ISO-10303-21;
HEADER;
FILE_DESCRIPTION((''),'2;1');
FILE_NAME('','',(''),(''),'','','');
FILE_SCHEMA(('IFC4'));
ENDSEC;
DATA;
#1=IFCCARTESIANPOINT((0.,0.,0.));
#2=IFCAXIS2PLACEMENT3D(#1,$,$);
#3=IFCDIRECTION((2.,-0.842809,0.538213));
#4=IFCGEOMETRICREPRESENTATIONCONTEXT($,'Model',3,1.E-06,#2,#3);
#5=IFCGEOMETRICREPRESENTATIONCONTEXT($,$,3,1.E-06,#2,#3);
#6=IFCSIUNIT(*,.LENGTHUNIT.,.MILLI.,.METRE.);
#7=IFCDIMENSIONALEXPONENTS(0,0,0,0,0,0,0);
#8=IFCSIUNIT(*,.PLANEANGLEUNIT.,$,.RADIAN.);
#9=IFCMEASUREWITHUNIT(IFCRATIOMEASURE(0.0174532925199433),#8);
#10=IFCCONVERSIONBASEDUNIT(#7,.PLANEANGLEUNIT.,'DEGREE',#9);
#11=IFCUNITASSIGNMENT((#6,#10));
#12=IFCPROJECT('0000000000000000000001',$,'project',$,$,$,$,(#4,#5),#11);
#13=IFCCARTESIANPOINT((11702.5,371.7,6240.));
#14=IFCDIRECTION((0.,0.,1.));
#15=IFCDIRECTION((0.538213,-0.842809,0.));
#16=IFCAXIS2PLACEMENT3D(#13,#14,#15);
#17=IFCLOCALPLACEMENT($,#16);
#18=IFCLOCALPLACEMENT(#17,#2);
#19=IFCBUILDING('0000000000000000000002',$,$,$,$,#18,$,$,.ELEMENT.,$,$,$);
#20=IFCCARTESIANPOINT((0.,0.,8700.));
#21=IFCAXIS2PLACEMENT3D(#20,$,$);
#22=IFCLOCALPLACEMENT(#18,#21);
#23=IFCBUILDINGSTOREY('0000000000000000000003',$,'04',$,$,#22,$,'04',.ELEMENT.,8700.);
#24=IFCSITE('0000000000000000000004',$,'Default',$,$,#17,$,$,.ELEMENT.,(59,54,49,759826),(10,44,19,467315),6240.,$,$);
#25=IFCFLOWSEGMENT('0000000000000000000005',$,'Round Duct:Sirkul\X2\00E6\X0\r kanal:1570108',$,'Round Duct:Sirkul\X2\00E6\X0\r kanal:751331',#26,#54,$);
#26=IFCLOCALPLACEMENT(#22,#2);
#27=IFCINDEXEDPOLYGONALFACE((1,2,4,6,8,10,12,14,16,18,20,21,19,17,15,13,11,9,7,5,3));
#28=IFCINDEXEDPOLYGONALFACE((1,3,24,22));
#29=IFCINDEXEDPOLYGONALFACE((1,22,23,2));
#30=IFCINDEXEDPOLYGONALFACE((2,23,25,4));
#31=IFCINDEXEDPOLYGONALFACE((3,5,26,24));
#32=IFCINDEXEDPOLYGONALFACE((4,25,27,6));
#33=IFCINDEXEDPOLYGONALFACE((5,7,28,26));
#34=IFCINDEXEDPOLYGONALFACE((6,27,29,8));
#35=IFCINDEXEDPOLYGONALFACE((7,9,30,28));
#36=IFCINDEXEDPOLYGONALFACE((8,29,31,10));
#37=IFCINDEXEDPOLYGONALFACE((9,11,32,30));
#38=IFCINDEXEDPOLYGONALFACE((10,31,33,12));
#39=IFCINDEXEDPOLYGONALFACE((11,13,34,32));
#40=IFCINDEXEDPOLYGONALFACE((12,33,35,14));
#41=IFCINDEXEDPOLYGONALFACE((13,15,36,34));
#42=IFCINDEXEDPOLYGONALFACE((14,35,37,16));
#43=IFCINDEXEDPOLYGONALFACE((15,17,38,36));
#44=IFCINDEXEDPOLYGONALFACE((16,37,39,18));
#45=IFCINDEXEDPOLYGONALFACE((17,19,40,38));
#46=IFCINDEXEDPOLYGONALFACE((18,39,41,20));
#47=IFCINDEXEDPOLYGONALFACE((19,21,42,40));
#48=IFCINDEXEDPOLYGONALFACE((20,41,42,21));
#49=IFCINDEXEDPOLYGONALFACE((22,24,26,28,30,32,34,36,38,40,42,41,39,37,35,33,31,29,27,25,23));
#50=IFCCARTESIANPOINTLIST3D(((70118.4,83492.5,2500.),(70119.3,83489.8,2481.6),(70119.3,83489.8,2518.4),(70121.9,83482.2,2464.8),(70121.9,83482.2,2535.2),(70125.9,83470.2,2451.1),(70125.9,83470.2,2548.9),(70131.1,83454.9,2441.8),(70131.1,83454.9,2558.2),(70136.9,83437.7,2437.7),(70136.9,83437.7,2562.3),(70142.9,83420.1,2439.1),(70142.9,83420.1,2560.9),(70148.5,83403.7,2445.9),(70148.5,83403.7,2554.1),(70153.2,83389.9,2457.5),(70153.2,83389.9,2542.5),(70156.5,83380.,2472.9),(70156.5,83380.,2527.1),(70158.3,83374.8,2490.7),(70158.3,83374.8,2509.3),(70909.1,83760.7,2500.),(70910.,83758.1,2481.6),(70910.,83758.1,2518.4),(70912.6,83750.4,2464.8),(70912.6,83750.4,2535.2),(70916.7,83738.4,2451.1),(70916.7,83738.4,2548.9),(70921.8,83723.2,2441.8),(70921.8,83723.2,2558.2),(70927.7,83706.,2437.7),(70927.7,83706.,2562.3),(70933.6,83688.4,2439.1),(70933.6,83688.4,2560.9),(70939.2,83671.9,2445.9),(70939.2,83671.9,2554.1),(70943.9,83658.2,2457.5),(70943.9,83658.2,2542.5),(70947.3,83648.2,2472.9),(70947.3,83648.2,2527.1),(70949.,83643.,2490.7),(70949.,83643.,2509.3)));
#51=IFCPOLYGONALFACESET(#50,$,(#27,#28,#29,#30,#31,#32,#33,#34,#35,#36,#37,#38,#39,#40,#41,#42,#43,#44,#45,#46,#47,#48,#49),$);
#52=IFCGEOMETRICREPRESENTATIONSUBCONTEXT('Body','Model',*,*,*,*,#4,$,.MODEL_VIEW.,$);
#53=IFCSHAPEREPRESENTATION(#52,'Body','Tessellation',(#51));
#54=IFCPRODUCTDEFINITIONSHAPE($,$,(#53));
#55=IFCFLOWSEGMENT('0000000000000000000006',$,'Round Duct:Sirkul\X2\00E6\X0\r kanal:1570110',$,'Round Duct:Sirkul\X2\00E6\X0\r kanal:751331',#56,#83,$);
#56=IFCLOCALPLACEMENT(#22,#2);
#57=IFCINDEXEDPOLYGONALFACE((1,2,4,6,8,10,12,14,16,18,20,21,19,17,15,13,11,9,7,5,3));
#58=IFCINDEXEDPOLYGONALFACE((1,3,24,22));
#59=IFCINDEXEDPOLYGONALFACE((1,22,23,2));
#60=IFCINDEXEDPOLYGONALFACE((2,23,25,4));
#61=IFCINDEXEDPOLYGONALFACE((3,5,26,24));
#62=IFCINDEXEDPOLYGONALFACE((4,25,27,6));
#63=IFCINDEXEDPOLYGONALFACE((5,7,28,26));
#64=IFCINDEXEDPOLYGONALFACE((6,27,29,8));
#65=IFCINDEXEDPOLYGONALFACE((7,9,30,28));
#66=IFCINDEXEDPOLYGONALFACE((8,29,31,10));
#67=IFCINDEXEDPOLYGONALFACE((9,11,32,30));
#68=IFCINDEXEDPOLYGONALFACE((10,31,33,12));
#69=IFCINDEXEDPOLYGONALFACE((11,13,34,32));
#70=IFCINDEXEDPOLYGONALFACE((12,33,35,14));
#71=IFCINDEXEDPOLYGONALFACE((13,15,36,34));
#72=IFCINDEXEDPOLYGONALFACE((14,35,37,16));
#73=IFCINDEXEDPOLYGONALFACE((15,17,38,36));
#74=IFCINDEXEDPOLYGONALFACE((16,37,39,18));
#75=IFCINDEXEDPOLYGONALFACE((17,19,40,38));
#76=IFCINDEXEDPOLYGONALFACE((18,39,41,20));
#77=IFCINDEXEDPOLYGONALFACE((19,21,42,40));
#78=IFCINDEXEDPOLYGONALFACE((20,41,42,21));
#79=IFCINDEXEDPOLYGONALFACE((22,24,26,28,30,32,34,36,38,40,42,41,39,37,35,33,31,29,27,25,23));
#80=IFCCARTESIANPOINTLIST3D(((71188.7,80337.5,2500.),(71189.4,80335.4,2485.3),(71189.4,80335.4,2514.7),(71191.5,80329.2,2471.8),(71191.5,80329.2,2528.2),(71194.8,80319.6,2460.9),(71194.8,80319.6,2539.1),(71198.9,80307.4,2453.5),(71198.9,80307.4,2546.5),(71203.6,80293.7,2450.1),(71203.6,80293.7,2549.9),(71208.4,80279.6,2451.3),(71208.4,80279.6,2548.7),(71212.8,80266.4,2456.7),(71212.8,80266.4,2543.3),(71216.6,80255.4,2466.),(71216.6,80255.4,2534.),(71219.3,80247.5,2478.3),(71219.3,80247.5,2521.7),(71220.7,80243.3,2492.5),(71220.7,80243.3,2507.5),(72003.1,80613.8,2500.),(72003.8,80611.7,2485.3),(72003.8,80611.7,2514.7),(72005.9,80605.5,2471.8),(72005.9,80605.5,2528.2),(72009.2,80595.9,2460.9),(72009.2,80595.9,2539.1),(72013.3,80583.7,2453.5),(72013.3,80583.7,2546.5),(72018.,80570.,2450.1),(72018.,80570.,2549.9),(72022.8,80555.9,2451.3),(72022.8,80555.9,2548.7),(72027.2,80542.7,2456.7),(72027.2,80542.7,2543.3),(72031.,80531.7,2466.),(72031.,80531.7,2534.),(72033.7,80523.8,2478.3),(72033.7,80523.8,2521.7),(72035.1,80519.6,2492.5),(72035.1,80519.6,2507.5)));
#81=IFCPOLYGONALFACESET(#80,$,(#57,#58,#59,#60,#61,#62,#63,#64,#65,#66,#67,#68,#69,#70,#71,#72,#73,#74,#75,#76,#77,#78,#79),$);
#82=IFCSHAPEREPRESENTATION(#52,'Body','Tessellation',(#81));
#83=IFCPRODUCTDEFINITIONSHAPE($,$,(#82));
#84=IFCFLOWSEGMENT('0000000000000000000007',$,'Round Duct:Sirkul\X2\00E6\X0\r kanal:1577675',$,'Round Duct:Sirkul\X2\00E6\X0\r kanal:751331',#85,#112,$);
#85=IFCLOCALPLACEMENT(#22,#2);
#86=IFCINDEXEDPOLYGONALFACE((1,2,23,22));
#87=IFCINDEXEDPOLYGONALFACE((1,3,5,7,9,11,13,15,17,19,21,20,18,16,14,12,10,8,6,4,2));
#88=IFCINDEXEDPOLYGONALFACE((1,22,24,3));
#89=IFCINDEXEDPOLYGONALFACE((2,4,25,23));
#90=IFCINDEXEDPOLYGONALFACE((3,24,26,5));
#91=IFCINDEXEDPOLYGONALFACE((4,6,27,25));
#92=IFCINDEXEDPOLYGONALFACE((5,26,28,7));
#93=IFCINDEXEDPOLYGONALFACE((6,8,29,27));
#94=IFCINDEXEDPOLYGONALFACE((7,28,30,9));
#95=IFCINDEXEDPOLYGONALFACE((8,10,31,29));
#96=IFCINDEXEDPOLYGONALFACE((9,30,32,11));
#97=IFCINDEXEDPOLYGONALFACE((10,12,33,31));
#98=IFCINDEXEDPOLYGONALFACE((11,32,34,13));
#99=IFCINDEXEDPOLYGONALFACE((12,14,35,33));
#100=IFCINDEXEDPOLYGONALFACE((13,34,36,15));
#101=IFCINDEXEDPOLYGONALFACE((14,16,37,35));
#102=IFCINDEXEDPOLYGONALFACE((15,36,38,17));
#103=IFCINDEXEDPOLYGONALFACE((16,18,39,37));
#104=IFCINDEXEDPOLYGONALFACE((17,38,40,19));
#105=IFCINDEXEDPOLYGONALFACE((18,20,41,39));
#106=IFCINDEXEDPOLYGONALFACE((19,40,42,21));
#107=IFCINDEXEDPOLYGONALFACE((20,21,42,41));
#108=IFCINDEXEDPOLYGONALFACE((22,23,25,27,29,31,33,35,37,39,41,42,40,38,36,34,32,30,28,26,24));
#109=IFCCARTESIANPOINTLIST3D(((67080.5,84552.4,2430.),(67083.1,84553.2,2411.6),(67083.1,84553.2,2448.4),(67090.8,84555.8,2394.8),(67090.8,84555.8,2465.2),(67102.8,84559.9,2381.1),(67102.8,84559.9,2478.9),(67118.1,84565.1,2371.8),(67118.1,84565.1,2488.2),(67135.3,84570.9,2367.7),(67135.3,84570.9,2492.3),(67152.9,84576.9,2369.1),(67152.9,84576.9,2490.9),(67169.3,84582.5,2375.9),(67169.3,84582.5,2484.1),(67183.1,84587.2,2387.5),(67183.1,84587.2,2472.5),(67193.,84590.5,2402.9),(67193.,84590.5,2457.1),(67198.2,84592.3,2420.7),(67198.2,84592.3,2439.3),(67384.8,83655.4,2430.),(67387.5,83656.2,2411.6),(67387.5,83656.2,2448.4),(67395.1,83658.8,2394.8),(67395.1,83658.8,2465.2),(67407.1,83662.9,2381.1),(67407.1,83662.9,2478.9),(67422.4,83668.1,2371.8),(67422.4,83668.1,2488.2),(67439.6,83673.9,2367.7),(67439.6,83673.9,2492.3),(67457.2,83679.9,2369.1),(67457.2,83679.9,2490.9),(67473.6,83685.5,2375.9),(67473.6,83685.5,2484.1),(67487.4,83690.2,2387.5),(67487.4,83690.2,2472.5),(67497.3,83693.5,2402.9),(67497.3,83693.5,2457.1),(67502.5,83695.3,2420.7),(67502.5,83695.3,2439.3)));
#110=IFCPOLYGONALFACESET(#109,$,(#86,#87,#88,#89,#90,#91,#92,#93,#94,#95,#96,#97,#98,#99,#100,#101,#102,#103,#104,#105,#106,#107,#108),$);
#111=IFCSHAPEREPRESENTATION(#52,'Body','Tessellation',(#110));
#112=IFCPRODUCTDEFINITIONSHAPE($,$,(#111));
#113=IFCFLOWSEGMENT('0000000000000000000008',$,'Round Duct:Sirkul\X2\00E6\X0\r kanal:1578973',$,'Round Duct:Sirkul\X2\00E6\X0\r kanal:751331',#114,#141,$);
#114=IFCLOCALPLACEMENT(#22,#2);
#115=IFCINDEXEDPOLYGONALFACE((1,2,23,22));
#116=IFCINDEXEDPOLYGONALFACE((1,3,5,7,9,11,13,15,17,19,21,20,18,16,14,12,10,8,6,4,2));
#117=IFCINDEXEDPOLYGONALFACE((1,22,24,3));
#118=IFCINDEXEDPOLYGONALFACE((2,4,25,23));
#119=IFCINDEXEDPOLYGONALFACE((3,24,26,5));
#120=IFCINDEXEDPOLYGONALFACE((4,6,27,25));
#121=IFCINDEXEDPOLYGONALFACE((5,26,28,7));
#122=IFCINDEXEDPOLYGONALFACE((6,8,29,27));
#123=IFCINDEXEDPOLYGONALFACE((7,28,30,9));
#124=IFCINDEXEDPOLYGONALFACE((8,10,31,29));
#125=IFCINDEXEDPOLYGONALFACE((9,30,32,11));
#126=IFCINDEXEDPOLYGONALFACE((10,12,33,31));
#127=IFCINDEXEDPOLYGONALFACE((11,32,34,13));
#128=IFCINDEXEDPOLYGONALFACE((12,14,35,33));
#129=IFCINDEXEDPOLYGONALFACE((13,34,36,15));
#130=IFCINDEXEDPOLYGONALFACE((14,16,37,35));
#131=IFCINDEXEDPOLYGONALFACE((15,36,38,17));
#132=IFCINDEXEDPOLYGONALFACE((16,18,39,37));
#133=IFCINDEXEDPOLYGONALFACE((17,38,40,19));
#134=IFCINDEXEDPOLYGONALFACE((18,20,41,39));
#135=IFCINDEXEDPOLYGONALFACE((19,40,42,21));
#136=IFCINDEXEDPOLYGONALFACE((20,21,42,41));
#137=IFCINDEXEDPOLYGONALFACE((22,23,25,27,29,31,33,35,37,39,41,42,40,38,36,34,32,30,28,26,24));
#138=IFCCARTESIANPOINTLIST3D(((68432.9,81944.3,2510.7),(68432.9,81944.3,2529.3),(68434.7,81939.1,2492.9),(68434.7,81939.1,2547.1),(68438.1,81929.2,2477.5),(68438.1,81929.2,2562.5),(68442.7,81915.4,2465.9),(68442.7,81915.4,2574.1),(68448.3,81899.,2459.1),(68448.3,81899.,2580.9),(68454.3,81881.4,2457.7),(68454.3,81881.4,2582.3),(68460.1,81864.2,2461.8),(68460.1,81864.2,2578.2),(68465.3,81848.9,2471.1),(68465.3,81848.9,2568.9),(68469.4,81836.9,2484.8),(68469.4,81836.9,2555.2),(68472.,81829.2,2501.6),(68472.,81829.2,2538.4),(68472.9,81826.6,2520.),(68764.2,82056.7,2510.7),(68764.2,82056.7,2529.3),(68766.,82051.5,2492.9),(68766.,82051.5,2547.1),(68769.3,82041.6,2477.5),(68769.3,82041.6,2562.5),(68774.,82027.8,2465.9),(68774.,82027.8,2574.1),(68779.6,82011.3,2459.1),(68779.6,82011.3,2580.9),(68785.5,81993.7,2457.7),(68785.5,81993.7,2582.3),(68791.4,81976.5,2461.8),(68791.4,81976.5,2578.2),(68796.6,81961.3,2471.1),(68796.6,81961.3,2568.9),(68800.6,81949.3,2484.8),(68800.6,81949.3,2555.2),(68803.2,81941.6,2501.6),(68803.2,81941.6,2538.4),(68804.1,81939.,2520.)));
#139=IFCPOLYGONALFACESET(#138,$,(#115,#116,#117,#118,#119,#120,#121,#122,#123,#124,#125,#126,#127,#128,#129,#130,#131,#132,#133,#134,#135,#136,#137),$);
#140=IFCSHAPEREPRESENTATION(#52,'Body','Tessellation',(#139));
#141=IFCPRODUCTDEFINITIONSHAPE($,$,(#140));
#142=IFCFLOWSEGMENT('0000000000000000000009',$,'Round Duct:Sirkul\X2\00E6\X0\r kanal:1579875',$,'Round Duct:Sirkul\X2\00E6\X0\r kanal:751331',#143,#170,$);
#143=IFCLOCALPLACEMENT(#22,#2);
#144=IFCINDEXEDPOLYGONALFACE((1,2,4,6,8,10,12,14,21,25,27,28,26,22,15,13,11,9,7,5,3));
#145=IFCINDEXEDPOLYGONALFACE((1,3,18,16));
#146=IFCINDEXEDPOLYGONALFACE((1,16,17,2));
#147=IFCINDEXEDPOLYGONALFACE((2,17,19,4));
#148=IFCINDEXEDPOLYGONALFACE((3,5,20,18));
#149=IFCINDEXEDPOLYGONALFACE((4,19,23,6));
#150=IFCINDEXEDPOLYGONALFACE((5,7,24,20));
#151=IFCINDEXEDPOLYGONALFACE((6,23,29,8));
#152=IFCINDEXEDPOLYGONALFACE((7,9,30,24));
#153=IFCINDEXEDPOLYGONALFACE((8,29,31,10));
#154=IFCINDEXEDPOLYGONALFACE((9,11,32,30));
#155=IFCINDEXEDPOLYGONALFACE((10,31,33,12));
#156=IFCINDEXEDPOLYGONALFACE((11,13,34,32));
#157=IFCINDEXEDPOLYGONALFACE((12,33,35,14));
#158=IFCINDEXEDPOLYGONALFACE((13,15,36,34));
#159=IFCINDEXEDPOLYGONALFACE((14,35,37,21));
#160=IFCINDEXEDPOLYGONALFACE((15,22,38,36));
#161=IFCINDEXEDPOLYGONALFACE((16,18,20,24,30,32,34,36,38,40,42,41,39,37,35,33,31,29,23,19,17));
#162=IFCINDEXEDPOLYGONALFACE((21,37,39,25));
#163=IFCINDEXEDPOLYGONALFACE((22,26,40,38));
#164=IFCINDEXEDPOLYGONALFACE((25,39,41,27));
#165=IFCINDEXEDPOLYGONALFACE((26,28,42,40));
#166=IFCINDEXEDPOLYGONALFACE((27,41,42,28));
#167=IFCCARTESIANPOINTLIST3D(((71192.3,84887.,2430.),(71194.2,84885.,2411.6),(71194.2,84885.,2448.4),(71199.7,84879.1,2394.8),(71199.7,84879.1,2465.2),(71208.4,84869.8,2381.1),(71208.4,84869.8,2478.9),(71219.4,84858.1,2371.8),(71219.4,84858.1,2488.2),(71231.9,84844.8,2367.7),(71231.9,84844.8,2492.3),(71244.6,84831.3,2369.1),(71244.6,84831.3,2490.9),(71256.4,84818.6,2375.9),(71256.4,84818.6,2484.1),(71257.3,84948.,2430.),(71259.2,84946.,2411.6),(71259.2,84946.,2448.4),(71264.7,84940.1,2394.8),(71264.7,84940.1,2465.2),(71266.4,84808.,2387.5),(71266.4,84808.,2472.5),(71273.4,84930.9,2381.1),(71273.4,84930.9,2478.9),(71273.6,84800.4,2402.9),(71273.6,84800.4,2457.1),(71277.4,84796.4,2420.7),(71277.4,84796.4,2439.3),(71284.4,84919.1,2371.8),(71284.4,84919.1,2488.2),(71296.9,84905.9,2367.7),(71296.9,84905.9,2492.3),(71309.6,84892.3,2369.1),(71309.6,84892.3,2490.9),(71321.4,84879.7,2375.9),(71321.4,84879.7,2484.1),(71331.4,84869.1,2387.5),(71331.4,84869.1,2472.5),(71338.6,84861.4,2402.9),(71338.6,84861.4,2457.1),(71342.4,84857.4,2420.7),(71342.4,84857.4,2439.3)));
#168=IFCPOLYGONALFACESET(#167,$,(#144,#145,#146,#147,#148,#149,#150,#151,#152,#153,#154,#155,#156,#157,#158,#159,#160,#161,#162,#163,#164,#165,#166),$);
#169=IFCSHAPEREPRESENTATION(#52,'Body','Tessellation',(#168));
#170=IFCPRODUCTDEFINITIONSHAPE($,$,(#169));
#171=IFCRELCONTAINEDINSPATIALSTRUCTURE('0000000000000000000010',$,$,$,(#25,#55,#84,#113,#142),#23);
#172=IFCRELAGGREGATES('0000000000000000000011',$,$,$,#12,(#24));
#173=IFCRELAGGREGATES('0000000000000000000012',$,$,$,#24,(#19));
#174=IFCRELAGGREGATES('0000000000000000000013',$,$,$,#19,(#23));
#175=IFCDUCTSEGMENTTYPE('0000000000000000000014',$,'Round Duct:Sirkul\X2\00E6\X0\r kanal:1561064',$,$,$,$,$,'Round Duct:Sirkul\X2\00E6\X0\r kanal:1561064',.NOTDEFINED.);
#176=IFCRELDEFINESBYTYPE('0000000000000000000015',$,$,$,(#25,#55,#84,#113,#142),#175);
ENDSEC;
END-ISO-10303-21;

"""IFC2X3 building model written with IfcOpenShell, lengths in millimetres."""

from ifc_helpers import new_model, entity, si_unit, converted_unit, direction, frame, frame_2d, origin, origin_2d_with_axis, place, context, subcontext, project, spatial, circle, extrude, type_object, element, save


model = new_model("IFC2X3")

# Units and contexts
model_context = context("Model", 3, precision=1e-06, world=origin(), true_north=direction((2.0, -0.842809, 0.538213)))
context_of_model = context(None, 3, precision=1e-06, world=origin(), true_north=direction((2.0, -0.842809, 0.538213)))
body_context = subcontext(model_context, "Body", "Model", "MODEL_VIEW")
ifc_project = project(units=[si_unit("LENGTHUNIT", "METRE", prefix="MILLI"), converted_unit("PLANEANGLEUNIT", "DEGREE", entity("IfcRatioMeasure", 0.0174532925199433), si_unit("PLANEANGLEUNIT", "RADIAN"), dimensions=[0, 0, 0, 0, 0, 0, 0])], contexts=[model_context, context_of_model])

# Site, building, storey
site_placement = place(None, frame((11702.5, 371.7, 6240.0), z_axis=(0.0, 0.0, 1.0), x_axis=(0.538213, -0.842809, 0.0)))
site = spatial("IfcSite", under=ifc_project, at=site_placement, Name="Default", CompositionType="ELEMENT", RefLatitude=(59, 54, 49, 759826), RefLongitude=(10, 44, 19, 467315), RefElevation=6240.0)
building_placement = place(site_placement, origin())
building = spatial("IfcBuilding", under=site, at=building_placement, CompositionType="ELEMENT")
storey_placement = place(building_placement, frame((0.0, 0.0, 8700.0)))
storey = spatial("IfcBuildingStorey", under=building, at=storey_placement, Name="04", LongName="04", CompositionType="ELEMENT", Elevation=8700.0)

# Flow segments
duct_segment_type = type_object("IfcDuctSegmentType", Name="Round Duct:Sirkulær kanal:1561064", ElementType="Round Duct:Sirkulær kanal:1561064", PredefinedType="NOTDEFINED")
flow_segment_1_placement = place(storey_placement, origin())
element("IfcFlowSegment", 1, at=flow_segment_1_placement, inside=storey, type_object=duct_segment_type, Name="Round Duct:Sirkulær kanal:1570108", ObjectType="Round Duct:Sirkulær kanal:751331", context=body_context, shape_type="SweptSolid", body=[
    extrude(circle(Radius=62.5, at=origin_2d_with_axis()), frame((70138.4, 83433.3, 2500.0), z_axis=(0.946986, 0.321274, 0.0), x_axis=(-0.321274, 0.946986, 0.0)), (0.0, 0.0, 1.0), 835.0),
])
flow_segment_2_placement = place(storey_placement, origin())
element("IfcFlowSegment", 2, at=flow_segment_2_placement, inside=storey, type_object=duct_segment_type, Name="Round Duct:Sirkulær kanal:1570110", ObjectType="Round Duct:Sirkulær kanal:751331", context=body_context, shape_type="SweptSolid", body=[
    extrude(circle(Radius=50.0, at=origin_2d_with_axis()), frame((71204.8, 80290.1, 2500.0), z_axis=(0.946986, 0.321274, 0.0), x_axis=(-0.321274, 0.946986, 0.0)), (0.0, 0.0, 1.0), 860.0),
])
flow_segment_3_placement = place(storey_placement, origin())
element("IfcFlowSegment", 3, at=flow_segment_3_placement, inside=storey, type_object=duct_segment_type, Name="Round Duct:Sirkulær kanal:1577675", ObjectType="Round Duct:Sirkulær kanal:751331", context=body_context, shape_type="SweptSolid", body=[
    extrude(circle(Radius=62.5, at=origin_2d_with_axis()), frame((67444.0, 83675.4, 2430.0), z_axis=(-0.321286, 0.946982, 0.0), x_axis=(-0.946982, -0.321286, 0.0)), (0.0, 0.0, 1.0), 947.2),
])
flow_segment_4_placement = place(storey_placement, origin())
element("IfcFlowSegment", 4, at=flow_segment_4_placement, inside=storey, type_object=duct_segment_type, Name="Round Duct:Sirkulær kanal:1578973", ObjectType="Round Duct:Sirkulær kanal:751331", context=body_context, shape_type="SweptSolid", body=[
    extrude(circle(Radius=62.5, at=origin_2d_with_axis()), frame((68452.8, 81885.8, 2520.0), z_axis=(0.946986, 0.321274, 0.0), x_axis=(0.321274, -0.946986, 0.0)), (0.0, 0.0, 1.0), 349.8),
])
flow_segment_5_placement = place(storey_placement, origin())
element("IfcFlowSegment", 5, at=flow_segment_5_placement, inside=storey, type_object=duct_segment_type, Name="Round Duct:Sirkulær kanal:1579875", ObjectType="Round Duct:Sirkulær kanal:751331", context=body_context, shape_type="SweptSolid", body=[
    extrude(circle(Radius=62.5, at=frame_2d((0.0, 0.0), x_axis=(1.0, 0.0))), frame((71235.0, 84841.4, 2430.0), z_axis=(0.728985, 0.68453, 0.0), x_axis=(-0.68453, 0.728985, 0.0)), (0.0, 0.0, 1.0), 89.2),
])

save(model, "model.ifc")
